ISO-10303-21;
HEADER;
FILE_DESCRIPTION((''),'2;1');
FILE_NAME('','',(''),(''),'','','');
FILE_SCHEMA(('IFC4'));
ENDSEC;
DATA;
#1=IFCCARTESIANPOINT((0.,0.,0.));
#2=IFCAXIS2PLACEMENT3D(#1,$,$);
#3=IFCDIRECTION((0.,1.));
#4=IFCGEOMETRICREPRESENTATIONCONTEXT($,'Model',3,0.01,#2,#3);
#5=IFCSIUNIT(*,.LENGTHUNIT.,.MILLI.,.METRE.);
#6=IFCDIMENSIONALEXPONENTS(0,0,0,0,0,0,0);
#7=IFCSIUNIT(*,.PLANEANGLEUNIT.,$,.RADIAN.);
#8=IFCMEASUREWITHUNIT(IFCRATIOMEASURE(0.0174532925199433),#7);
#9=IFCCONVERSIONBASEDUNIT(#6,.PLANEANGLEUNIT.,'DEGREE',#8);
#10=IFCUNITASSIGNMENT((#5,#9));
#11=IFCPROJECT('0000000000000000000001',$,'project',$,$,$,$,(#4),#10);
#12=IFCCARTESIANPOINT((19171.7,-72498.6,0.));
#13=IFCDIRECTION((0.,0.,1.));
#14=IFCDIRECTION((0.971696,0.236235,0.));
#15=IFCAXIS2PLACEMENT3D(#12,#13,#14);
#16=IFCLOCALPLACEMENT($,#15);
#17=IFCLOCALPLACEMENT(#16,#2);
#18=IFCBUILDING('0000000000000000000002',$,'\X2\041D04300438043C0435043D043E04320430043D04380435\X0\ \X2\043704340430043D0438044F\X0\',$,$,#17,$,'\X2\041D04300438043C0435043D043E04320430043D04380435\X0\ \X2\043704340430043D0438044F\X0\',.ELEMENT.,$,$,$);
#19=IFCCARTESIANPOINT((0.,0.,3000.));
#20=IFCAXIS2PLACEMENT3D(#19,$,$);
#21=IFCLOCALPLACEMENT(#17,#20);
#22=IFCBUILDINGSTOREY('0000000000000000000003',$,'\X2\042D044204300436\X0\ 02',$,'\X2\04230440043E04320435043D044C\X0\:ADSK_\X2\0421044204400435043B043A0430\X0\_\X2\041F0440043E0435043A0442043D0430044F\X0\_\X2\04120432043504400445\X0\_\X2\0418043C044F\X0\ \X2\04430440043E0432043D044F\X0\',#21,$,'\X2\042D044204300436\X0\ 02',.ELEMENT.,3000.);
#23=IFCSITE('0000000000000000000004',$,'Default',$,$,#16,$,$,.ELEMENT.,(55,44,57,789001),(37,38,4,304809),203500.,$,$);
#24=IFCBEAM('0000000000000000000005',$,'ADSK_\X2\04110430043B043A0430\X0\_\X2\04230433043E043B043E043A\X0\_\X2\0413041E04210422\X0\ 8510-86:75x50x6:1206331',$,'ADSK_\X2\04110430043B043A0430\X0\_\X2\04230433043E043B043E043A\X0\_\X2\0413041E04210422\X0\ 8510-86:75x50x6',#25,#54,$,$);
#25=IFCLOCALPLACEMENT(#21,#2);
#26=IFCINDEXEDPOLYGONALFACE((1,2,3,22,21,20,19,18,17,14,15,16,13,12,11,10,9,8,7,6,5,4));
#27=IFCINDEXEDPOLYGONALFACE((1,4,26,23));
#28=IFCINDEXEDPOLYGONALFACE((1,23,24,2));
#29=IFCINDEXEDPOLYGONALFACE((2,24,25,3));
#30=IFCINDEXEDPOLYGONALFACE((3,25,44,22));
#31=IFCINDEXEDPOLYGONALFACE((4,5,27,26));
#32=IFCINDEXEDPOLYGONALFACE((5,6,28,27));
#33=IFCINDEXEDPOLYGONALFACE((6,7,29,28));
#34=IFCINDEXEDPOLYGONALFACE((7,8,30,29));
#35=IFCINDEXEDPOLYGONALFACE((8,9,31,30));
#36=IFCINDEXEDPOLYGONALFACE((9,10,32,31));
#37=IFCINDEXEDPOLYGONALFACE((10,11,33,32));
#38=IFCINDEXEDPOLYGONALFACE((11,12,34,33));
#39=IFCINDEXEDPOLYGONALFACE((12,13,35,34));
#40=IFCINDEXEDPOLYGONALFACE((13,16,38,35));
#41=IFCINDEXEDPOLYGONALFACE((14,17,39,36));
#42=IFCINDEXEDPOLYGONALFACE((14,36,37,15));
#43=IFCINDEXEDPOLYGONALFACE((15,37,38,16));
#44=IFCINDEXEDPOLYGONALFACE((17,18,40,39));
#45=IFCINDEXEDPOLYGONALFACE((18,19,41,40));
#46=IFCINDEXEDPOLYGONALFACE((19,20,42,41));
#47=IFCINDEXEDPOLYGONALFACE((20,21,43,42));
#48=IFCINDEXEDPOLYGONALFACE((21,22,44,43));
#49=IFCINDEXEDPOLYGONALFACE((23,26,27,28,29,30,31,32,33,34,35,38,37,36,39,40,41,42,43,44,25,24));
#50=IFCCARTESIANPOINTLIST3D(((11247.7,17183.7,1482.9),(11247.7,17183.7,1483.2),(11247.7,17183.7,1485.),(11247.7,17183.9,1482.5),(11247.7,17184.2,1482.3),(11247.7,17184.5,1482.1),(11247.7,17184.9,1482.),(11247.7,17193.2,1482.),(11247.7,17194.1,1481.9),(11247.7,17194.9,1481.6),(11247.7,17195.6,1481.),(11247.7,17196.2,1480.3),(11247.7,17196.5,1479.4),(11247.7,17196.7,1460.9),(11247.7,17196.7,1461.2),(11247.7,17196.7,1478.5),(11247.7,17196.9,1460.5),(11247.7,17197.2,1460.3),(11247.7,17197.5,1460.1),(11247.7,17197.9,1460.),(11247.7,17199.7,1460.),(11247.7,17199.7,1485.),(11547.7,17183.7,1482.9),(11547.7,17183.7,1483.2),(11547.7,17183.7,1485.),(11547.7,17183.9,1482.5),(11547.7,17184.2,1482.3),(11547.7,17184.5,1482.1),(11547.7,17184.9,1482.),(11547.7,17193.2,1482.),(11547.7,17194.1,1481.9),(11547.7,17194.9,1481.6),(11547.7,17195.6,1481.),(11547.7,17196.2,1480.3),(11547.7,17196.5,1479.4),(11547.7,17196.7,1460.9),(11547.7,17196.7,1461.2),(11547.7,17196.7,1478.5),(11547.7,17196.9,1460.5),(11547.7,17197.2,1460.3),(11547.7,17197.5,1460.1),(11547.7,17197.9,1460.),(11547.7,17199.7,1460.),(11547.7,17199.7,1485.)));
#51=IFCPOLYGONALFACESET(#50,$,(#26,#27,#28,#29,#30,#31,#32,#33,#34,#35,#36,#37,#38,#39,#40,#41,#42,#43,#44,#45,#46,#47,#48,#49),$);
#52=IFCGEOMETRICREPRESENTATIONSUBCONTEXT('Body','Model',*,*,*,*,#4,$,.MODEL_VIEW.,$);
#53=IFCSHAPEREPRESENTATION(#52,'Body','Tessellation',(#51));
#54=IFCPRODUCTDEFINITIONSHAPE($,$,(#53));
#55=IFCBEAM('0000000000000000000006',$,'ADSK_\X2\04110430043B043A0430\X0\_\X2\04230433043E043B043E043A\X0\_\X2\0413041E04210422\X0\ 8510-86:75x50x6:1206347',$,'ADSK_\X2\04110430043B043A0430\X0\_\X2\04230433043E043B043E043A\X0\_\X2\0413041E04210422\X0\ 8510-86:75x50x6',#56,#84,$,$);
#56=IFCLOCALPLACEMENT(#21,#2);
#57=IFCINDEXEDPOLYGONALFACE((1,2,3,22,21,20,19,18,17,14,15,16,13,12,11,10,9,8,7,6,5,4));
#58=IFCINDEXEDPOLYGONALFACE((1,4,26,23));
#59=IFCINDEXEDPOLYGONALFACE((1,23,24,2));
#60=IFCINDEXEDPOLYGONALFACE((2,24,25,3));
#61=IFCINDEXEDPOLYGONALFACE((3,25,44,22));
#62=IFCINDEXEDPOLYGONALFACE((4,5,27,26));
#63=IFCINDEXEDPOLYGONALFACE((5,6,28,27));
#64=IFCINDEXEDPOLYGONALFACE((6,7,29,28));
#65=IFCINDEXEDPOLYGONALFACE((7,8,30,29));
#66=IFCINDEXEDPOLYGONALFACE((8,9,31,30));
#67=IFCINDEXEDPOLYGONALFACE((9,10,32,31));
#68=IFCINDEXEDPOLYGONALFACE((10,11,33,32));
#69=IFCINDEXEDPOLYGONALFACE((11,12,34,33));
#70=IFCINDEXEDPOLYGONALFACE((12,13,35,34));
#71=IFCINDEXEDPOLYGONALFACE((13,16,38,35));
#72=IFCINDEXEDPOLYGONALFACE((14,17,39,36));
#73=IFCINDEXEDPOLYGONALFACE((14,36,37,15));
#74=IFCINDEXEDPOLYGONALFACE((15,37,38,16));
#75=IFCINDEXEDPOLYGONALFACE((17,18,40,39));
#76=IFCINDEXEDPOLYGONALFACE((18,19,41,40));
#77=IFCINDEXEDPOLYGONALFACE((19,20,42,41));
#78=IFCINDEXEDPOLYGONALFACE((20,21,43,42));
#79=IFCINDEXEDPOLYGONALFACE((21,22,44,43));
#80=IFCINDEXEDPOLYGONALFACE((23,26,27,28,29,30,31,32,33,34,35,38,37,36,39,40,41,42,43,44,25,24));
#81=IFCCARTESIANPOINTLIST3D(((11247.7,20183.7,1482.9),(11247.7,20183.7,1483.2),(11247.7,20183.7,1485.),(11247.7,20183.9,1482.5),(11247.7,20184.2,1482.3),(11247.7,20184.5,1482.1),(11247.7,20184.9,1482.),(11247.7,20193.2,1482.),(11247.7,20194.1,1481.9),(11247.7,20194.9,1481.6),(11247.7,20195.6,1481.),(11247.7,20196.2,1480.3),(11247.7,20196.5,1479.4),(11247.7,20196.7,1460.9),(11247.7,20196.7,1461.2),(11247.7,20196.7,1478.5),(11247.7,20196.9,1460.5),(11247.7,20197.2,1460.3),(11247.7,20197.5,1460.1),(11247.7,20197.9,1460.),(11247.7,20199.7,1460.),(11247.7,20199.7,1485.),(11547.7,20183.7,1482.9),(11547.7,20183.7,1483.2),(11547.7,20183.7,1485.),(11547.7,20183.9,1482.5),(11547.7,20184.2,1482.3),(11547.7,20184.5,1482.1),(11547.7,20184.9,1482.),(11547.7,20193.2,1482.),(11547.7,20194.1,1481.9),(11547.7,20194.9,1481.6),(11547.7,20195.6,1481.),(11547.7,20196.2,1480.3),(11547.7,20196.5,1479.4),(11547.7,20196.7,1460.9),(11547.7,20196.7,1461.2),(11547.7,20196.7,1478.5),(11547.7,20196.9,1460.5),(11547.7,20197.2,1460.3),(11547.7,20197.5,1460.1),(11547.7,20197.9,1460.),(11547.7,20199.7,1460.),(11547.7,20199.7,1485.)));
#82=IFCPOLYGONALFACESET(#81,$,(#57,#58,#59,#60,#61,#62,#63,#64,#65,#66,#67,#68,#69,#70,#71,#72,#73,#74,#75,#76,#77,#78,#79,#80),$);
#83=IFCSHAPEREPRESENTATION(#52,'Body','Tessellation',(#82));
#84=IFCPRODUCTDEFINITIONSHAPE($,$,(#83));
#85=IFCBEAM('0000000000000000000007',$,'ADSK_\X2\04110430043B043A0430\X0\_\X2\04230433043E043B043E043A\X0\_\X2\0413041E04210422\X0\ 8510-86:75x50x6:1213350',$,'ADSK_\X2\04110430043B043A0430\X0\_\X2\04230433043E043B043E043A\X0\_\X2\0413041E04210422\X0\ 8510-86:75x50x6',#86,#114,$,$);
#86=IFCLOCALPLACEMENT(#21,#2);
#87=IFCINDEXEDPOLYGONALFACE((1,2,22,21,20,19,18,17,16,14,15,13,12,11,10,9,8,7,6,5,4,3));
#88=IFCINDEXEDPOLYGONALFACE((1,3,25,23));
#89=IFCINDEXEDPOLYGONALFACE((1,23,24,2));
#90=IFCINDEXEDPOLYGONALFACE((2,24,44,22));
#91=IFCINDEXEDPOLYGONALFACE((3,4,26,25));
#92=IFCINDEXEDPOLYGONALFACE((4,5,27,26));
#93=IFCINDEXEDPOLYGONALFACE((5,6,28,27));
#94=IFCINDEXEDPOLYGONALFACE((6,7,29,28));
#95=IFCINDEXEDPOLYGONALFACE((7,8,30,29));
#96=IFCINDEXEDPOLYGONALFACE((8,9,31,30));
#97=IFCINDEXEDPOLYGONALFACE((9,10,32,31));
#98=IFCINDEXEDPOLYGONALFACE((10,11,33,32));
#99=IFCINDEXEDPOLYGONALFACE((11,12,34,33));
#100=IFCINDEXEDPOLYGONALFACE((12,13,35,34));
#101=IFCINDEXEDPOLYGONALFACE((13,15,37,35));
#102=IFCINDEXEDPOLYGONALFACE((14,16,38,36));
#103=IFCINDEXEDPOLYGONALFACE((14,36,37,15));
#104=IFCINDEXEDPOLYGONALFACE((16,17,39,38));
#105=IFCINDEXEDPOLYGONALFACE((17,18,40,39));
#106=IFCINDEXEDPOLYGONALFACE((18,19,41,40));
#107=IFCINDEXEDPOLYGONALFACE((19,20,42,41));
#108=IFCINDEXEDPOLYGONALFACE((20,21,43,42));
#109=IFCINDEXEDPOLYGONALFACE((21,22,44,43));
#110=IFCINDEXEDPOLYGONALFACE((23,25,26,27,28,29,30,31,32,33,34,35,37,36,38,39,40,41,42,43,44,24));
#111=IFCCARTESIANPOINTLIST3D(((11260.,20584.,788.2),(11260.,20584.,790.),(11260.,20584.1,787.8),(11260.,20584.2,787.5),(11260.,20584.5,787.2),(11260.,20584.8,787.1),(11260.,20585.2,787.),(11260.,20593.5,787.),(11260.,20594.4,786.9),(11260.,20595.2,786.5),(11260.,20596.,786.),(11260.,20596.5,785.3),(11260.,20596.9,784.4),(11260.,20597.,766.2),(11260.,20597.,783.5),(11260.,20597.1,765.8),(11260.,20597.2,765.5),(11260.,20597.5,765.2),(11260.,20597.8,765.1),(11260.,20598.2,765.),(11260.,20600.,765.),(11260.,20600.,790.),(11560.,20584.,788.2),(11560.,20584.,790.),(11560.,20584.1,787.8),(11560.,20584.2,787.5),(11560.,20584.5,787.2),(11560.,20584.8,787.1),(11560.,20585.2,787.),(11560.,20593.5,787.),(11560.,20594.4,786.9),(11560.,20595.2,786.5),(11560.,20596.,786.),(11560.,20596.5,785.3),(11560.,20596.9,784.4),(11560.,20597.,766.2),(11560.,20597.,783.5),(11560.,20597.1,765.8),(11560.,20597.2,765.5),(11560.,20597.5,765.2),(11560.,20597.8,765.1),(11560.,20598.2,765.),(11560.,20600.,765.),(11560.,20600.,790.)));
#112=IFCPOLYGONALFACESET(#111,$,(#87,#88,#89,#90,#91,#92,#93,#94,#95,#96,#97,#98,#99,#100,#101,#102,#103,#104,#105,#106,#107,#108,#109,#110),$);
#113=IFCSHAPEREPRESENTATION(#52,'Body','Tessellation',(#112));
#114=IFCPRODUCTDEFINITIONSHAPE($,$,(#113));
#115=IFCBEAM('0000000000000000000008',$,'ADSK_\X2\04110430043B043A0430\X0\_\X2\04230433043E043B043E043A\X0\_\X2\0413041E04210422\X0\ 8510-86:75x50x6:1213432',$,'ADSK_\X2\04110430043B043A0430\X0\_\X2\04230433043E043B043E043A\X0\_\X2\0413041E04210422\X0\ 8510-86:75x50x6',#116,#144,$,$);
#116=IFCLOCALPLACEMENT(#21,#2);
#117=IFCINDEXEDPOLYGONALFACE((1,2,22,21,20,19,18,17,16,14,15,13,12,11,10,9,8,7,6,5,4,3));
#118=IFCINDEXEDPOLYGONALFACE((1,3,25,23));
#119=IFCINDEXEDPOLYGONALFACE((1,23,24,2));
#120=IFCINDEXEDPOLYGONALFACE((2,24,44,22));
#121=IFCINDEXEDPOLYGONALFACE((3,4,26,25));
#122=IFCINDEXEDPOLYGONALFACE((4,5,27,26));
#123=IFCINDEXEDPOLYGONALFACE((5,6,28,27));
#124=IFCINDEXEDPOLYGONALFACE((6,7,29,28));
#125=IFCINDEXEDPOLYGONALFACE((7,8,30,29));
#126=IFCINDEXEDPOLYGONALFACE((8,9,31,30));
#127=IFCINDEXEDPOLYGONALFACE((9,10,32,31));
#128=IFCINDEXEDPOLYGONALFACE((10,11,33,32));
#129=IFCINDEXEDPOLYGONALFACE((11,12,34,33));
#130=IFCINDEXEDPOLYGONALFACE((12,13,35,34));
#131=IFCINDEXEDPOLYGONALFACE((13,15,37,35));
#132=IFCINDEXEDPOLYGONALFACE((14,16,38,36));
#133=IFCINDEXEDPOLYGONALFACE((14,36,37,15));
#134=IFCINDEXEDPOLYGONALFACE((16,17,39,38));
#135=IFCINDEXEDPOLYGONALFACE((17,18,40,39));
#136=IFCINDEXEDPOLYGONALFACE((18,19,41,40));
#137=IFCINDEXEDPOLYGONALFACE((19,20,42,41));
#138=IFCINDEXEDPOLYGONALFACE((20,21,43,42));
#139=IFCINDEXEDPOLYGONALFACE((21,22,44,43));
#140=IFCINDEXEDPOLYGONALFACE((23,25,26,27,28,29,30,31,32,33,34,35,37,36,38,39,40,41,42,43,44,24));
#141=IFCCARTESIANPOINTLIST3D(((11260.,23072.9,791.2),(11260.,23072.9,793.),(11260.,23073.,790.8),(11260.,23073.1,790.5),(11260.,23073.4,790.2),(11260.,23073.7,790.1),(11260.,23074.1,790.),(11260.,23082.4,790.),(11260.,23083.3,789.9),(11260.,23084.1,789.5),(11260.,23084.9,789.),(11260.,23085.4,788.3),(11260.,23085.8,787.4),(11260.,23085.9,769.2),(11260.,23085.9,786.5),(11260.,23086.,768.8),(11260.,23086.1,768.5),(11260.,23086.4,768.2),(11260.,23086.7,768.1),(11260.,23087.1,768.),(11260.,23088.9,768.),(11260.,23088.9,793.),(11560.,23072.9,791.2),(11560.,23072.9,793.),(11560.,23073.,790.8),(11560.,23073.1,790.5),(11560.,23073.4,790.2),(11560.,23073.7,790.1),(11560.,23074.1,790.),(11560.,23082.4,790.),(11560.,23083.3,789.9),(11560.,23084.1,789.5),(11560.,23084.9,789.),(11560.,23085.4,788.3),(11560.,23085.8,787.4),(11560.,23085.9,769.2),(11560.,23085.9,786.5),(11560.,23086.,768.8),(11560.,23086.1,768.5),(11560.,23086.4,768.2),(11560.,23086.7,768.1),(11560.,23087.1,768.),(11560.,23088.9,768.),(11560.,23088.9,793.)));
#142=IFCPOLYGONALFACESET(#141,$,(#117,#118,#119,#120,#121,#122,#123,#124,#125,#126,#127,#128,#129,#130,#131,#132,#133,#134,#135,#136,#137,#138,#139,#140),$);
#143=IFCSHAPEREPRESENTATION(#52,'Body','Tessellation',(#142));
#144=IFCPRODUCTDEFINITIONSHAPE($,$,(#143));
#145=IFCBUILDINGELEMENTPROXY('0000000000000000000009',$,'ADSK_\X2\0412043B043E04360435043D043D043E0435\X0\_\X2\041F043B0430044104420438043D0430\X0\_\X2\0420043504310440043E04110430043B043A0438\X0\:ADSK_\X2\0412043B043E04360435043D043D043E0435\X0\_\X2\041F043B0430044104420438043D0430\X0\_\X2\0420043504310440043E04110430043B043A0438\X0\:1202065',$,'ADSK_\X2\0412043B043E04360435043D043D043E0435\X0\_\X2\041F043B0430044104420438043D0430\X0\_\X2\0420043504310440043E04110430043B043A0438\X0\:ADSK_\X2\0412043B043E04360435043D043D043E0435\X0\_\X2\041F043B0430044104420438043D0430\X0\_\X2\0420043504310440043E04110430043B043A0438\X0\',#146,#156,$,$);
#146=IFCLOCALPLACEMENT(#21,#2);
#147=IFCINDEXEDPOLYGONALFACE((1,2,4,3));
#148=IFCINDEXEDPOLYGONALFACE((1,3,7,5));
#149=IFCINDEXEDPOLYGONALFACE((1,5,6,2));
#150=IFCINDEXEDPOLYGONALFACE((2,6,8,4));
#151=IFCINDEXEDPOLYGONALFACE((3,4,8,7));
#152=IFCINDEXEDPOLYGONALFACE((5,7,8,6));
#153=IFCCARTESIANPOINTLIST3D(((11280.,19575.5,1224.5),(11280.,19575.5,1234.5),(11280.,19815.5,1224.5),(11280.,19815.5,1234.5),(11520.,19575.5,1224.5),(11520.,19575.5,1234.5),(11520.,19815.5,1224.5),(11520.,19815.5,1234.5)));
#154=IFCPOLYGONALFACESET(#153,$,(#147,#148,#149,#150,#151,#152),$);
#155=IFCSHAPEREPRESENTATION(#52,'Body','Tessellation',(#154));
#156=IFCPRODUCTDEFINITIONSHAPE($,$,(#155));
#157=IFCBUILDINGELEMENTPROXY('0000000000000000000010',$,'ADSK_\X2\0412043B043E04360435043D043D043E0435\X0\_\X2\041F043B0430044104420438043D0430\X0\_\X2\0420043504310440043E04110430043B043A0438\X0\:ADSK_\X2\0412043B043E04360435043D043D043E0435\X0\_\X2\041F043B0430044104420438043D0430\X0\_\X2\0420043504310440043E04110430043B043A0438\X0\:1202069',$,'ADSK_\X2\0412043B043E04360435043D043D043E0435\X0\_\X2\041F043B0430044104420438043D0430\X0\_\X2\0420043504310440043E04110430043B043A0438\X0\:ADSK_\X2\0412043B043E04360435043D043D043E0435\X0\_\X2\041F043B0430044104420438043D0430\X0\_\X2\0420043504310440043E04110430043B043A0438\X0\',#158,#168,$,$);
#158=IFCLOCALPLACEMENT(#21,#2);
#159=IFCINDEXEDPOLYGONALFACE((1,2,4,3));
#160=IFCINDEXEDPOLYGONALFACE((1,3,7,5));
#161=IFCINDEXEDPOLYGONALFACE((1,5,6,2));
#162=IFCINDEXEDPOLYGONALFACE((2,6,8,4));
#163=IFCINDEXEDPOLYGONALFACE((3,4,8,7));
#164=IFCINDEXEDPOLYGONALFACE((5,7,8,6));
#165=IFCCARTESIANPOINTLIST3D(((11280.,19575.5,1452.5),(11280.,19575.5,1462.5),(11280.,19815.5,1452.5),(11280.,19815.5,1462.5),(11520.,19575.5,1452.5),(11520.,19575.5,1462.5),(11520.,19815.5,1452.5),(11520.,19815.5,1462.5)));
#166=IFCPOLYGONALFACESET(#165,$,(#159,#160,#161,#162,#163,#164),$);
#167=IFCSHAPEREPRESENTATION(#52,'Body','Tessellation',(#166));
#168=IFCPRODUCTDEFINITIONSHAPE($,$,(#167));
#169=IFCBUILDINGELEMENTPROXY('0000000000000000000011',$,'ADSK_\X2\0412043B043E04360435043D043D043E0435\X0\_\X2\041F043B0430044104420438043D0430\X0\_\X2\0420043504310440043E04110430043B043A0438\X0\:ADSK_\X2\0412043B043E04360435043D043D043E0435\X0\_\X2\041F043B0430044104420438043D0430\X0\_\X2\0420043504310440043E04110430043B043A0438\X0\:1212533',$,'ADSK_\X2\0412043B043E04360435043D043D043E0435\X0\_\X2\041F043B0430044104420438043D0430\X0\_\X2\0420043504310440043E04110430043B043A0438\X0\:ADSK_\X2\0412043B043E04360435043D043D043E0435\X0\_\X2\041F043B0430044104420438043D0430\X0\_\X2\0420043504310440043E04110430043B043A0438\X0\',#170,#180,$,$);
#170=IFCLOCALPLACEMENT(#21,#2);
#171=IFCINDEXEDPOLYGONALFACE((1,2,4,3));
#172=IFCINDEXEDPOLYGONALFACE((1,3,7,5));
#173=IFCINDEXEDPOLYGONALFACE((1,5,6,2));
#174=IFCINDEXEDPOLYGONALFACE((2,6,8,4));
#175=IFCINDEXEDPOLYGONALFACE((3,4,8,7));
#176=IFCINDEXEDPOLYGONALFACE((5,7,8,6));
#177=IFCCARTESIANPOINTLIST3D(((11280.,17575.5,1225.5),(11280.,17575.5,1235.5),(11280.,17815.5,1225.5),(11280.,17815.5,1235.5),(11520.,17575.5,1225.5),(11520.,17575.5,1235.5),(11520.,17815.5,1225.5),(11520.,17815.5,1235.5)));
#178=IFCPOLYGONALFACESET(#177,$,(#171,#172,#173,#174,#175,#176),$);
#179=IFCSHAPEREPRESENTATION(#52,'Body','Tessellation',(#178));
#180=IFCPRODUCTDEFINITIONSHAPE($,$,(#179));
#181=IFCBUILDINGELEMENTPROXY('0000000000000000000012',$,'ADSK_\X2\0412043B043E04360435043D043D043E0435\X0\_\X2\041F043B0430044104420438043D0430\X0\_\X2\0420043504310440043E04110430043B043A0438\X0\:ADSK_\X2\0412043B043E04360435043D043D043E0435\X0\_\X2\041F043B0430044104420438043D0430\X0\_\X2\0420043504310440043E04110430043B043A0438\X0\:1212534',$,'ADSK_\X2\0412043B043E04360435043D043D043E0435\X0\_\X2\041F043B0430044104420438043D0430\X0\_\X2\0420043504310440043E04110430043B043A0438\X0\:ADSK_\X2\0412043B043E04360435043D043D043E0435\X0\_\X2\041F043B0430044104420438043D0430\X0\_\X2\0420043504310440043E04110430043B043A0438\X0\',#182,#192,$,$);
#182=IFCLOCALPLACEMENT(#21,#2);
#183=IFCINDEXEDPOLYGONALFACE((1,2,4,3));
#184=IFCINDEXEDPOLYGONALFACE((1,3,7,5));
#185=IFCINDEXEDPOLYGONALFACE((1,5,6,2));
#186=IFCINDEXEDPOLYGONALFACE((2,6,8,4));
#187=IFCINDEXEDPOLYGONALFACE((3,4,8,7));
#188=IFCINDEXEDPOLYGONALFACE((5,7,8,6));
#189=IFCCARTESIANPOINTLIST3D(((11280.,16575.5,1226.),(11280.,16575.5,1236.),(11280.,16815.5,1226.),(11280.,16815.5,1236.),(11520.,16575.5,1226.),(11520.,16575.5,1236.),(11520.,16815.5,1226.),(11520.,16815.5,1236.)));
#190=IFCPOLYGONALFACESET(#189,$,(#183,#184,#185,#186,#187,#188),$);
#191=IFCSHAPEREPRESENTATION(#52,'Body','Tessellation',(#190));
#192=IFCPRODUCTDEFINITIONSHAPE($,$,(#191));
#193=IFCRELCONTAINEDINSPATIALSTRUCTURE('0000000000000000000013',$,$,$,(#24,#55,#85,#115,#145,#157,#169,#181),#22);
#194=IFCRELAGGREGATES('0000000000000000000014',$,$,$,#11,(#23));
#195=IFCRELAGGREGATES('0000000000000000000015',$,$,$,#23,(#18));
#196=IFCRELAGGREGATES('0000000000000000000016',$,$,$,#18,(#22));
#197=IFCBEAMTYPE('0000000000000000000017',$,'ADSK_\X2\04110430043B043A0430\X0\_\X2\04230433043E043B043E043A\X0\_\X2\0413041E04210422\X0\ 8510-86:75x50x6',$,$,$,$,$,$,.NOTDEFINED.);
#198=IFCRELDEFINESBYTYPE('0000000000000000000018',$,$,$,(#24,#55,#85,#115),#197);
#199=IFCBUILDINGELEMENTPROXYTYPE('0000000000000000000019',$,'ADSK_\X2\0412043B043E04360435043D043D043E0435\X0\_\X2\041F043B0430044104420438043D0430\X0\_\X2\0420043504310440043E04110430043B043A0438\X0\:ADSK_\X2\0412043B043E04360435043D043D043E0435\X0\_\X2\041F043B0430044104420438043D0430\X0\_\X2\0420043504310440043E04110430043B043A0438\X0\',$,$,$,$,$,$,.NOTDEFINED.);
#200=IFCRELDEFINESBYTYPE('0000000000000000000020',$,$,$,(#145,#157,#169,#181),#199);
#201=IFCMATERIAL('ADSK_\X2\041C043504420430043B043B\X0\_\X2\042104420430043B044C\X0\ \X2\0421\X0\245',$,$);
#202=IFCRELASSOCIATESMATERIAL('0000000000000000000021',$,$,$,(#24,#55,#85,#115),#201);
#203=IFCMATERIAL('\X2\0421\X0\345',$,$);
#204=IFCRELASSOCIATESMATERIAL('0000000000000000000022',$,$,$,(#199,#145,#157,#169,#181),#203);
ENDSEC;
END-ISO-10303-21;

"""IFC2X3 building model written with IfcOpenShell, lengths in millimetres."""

from ifc_helpers import new_model, entity, si_unit, converted_unit, direction, frame, frame_2d, origin, origin_2d_with_axis, place, context, subcontext, project, spatial, polyline, circle_curve, parameter, trimmed, segment, composite_curve, rectangle, outline, extrude, source, transform, mapped, material, type_object, type_shapes, element, save


model = new_model("IFC2X3")

# Units and contexts
model_context = context("Model", 3, precision=0.01, world=origin(), true_north=direction((0.0, 1.0)))
body_context = subcontext(model_context, "Body", "Model", "MODEL_VIEW")
ifc_project = project(units=[si_unit("LENGTHUNIT", "METRE", prefix="MILLI"), converted_unit("PLANEANGLEUNIT", "DEGREE", entity("IfcRatioMeasure", 0.0174532925199433), si_unit("PLANEANGLEUNIT", "RADIAN"), dimensions=[0, 0, 0, 0, 0, 0, 0])], contexts=[model_context])

# Site, building, storey
site_placement = place(None, frame((19171.7, -72498.6, 0.0), z_axis=(0.0, 0.0, 1.0), x_axis=(0.971696, 0.236235, 0.0)))
site = spatial("IfcSite", under=ifc_project, at=site_placement, Name="Default", CompositionType="ELEMENT", RefLatitude=(55, 44, 57, 789001), RefLongitude=(37, 38, 4, 304809), RefElevation=203500.0)
building_placement = place(site_placement, origin())
building = spatial("IfcBuilding", under=site, at=building_placement, Name="Наименование здания", LongName="Наименование здания", CompositionType="ELEMENT")
storey_placement = place(building_placement, frame((0.0, 0.0, 3000.0)))
storey = spatial("IfcBuildingStorey", under=building, at=storey_placement, Name="Этаж 02", ObjectType="Уровень:ADSK_Стрелка_Проектная_Вверх_Имя уровня", LongName="Этаж 02", CompositionType="ELEMENT", Elevation=3000.0)

# Beams
ifc_material_1 = material(Name="ADSK_Металл_Сталь С245")
beam_type_1 = type_object("IfcBeamType", Name="ADSK_Балка_Уголок_ГОСТ 8510-86:75x50x6", PredefinedType="NOTDEFINED")
beam_1_placement = place(storey_placement, frame((11247.7, 17195.5, 1460.0)))
element("IfcBeam", 1, at=beam_1_placement, inside=storey, type_object=beam_type_1, material=ifc_material_1, Name="ADSK_Балка_Уголок_ГОСТ 8510-86:75x50x6:1206331", ObjectType="ADSK_Балка_Уголок_ГОСТ 8510-86:75x50x6", context=body_context, shape_type="SweptSolid", body=[
    extrude(outline(composite_curve([segment(polyline([(-9.8, -9.2), (-8.0, -9.2)]), True, "CONTINUOUS"), segment(trimmed(circle_curve(frame_2d((-8.0, -8.0), x_axis=(0.0, -1.0)), 1.2), [parameter(0.0)], [parameter(90.0)], True, "PARAMETER"), True, "CONTINUOUS"), segment(polyline([(-6.8, -8.0), (-6.8, 0.3)]), True, "CONTINUOUS"), segment(trimmed(circle_curve(frame_2d((-3.3, 0.3), x_axis=(-1.0, 0.0)), 3.5), [parameter(270.0)], [parameter(0.0)], True, "PARAMETER"), False, "CONTINUOUS"), segment(polyline([(-3.3, 3.8), (14.0, 3.8)]), True, "CONTINUOUS"), segment(trimmed(circle_curve(frame_2d((14.0, 5.0), x_axis=(0.0, -1.0)), 1.2), [parameter(0.0)], [parameter(90.0)], True, "PARAMETER"), True, "CONTINUOUS"), segment(polyline([(15.2, 5.0), (15.2, 6.8)]), True, "CONTINUOUS"), segment(polyline([(15.2, 6.8), (-9.8, 6.8)]), True, "CONTINUOUS"), segment(polyline([(-9.8, 6.8), (-9.8, -9.2)]), True, "CONTINUOUS")], self_intersect=False)), frame((0.0, -2.6, 15.2), z_axis=(1.0, 0.0, 0.0), x_axis=(0.0, 0.0, -1.0)), (0.0, 0.0, 1.0), 300.0),
])
beam_2_placement = place(storey_placement, frame((11247.7, 20195.5, 1460.0)))
element("IfcBeam", 2, at=beam_2_placement, inside=storey, type_object=beam_type_1, material=ifc_material_1, Name="ADSK_Балка_Уголок_ГОСТ 8510-86:75x50x6:1206347", ObjectType="ADSK_Балка_Уголок_ГОСТ 8510-86:75x50x6", context=body_context, shape_type="SweptSolid", body=[
    extrude(outline(composite_curve([segment(polyline([(-9.8, -9.2), (-8.0, -9.2)]), True, "CONTINUOUS"), segment(trimmed(circle_curve(frame_2d((-8.0, -8.0), x_axis=(0.0, -1.0)), 1.2), [parameter(0.0)], [parameter(90.0)], True, "PARAMETER"), True, "CONTINUOUS"), segment(polyline([(-6.8, -8.0), (-6.8, 0.3)]), True, "CONTINUOUS"), segment(trimmed(circle_curve(frame_2d((-3.3, 0.3), x_axis=(-1.0, 0.0)), 3.5), [parameter(270.0)], [parameter(0.0)], True, "PARAMETER"), False, "CONTINUOUS"), segment(polyline([(-3.3, 3.8), (14.0, 3.8)]), True, "CONTINUOUS"), segment(trimmed(circle_curve(frame_2d((14.0, 5.0), x_axis=(0.0, -1.0)), 1.2), [parameter(0.0)], [parameter(90.0)], True, "PARAMETER"), True, "CONTINUOUS"), segment(polyline([(15.2, 5.0), (15.2, 6.8)]), True, "CONTINUOUS"), segment(polyline([(15.2, 6.8), (-9.8, 6.8)]), True, "CONTINUOUS"), segment(polyline([(-9.8, 6.8), (-9.8, -9.2)]), True, "CONTINUOUS")], self_intersect=False)), frame((0.0, -2.6, 15.2), z_axis=(1.0, 0.0, 0.0), x_axis=(0.0, 0.0, -1.0)), (0.0, 0.0, 1.0), 300.0),
])
for number, where, name in (
    (3, (11260.0, 20595.8, 765.0), "ADSK_Балка_Уголок_ГОСТ 8510-86:75x50x6:1213350"),
    (4, (11260.0, 23084.7, 768.0), "ADSK_Балка_Уголок_ГОСТ 8510-86:75x50x6:1213432"),
):
    element("IfcBeam", number, at=place(storey_placement, frame(where)), inside=storey, type_object=beam_type_1, material=ifc_material_1, Name=name, ObjectType="ADSK_Балка_Уголок_ГОСТ 8510-86:75x50x6", context=body_context, shape_type="SweptSolid", body=[
        extrude(outline(composite_curve([segment(polyline([(-9.8, -9.2), (-8.0, -9.2)]), True, "CONTINUOUS"), segment(trimmed(circle_curve(frame_2d((-8.0, -8.0), x_axis=(0.0, -1.0)), 1.2), [parameter(0.0)], [parameter(90.0)], True, "PARAMETER"), True, "CONTINUOUS"), segment(polyline([(-6.8, -8.0), (-6.8, 0.3)]), True, "CONTINUOUS"), segment(trimmed(circle_curve(frame_2d((-3.3, 0.3), x_axis=(-1.0, 0.0)), 3.5), [parameter(270.0)], [parameter(0.0)], True, "PARAMETER"), False, "CONTINUOUS"), segment(polyline([(-3.3, 3.8), (14.0, 3.8)]), True, "CONTINUOUS"), segment(trimmed(circle_curve(frame_2d((14.0, 5.0), x_axis=(0.0, -1.0)), 1.2), [parameter(0.0)], [parameter(90.0)], True, "PARAMETER"), True, "CONTINUOUS"), segment(polyline([(15.2, 5.0), (15.2, 6.8)]), True, "CONTINUOUS"), segment(polyline([(15.2, 6.8), (-9.8, 6.8)]), True, "CONTINUOUS"), segment(polyline([(-9.8, 6.8), (-9.8, -9.2)]), True, "CONTINUOUS")], self_intersect=False)), frame((0.0, -2.6, 15.2), z_axis=(1.0, 0.0, 0.0), x_axis=(0.0, 0.0, -1.0)), (0.0, 0.0, 1.0), 300.0),
    ])

# Building element proxies
ifc_material_2 = material(Name="С345")
building_element_proxy_type = type_object("IfcBuildingElementProxyType", Name="ADSK_Вложенное_Пластина_РеброБалки:ADSK_Вложенное_Пластина_РеброБалки", PredefinedType="NOTDEFINED", material=ifc_material_2)
shared_shape = source(origin(), body_context, "Body", "SweptSolid", [
    extrude(rectangle(XDim=10.0, YDim=240.0, at=origin_2d_with_axis()), frame((0.0, 0.0, -120.0), z_axis=(0.0, 0.0, 1.0), x_axis=(0.0, 1.0, 0.0)), (0.0, 0.0, 1.0), 240.0),
])
type_shapes(building_element_proxy_type, [shared_shape])
for number, where, z_axis, x_axis, name in (
    (5, (11400.0, 19695.5, 1229.5), (0.0, 1.0, 0.0), (1.0, 0.0, 0.0), "ADSK_Вложенное_Пластина_РеброБалки:ADSK_Вложенное_Пластина_РеброБалки:1202065"),
    (6, (11400.0, 19695.5, 1457.5), (0.0, 1.0, 0.0), (1.0, 0.0, 0.0), "ADSK_Вложенное_Пластина_РеброБалки:ADSK_Вложенное_Пластина_РеброБалки:1202069"),
    (7, (11400.0, 17695.5, 1230.5), (0.0, 1.0, 0.0), (1.0, 0.0, 0.0), "ADSK_Вложенное_Пластина_РеброБалки:ADSK_Вложенное_Пластина_РеброБалки:1212533"),
    (8, (11400.0, 16695.5, 1231.0), (0.0, 1.0, 0.0), (1.0, 0.0, 0.0), "ADSK_Вложенное_Пластина_РеброБалки:ADSK_Вложенное_Пластина_РеброБалки:1212534"),
):
    element("IfcBuildingElementProxy", number, at=place(storey_placement, frame(where, z_axis=z_axis, x_axis=x_axis)), inside=storey, type_object=building_element_proxy_type, material=ifc_material_2, Name=name, ObjectType="ADSK_Вложенное_Пластина_РеброБалки:ADSK_Вложенное_Пластина_РеброБалки", context=body_context, shape_type="MappedRepresentation", body=[
        mapped(shared_shape, transform((0.0, 0.0, 0.0), scale=1.0)),
    ])

save(model, "model.ifc")
